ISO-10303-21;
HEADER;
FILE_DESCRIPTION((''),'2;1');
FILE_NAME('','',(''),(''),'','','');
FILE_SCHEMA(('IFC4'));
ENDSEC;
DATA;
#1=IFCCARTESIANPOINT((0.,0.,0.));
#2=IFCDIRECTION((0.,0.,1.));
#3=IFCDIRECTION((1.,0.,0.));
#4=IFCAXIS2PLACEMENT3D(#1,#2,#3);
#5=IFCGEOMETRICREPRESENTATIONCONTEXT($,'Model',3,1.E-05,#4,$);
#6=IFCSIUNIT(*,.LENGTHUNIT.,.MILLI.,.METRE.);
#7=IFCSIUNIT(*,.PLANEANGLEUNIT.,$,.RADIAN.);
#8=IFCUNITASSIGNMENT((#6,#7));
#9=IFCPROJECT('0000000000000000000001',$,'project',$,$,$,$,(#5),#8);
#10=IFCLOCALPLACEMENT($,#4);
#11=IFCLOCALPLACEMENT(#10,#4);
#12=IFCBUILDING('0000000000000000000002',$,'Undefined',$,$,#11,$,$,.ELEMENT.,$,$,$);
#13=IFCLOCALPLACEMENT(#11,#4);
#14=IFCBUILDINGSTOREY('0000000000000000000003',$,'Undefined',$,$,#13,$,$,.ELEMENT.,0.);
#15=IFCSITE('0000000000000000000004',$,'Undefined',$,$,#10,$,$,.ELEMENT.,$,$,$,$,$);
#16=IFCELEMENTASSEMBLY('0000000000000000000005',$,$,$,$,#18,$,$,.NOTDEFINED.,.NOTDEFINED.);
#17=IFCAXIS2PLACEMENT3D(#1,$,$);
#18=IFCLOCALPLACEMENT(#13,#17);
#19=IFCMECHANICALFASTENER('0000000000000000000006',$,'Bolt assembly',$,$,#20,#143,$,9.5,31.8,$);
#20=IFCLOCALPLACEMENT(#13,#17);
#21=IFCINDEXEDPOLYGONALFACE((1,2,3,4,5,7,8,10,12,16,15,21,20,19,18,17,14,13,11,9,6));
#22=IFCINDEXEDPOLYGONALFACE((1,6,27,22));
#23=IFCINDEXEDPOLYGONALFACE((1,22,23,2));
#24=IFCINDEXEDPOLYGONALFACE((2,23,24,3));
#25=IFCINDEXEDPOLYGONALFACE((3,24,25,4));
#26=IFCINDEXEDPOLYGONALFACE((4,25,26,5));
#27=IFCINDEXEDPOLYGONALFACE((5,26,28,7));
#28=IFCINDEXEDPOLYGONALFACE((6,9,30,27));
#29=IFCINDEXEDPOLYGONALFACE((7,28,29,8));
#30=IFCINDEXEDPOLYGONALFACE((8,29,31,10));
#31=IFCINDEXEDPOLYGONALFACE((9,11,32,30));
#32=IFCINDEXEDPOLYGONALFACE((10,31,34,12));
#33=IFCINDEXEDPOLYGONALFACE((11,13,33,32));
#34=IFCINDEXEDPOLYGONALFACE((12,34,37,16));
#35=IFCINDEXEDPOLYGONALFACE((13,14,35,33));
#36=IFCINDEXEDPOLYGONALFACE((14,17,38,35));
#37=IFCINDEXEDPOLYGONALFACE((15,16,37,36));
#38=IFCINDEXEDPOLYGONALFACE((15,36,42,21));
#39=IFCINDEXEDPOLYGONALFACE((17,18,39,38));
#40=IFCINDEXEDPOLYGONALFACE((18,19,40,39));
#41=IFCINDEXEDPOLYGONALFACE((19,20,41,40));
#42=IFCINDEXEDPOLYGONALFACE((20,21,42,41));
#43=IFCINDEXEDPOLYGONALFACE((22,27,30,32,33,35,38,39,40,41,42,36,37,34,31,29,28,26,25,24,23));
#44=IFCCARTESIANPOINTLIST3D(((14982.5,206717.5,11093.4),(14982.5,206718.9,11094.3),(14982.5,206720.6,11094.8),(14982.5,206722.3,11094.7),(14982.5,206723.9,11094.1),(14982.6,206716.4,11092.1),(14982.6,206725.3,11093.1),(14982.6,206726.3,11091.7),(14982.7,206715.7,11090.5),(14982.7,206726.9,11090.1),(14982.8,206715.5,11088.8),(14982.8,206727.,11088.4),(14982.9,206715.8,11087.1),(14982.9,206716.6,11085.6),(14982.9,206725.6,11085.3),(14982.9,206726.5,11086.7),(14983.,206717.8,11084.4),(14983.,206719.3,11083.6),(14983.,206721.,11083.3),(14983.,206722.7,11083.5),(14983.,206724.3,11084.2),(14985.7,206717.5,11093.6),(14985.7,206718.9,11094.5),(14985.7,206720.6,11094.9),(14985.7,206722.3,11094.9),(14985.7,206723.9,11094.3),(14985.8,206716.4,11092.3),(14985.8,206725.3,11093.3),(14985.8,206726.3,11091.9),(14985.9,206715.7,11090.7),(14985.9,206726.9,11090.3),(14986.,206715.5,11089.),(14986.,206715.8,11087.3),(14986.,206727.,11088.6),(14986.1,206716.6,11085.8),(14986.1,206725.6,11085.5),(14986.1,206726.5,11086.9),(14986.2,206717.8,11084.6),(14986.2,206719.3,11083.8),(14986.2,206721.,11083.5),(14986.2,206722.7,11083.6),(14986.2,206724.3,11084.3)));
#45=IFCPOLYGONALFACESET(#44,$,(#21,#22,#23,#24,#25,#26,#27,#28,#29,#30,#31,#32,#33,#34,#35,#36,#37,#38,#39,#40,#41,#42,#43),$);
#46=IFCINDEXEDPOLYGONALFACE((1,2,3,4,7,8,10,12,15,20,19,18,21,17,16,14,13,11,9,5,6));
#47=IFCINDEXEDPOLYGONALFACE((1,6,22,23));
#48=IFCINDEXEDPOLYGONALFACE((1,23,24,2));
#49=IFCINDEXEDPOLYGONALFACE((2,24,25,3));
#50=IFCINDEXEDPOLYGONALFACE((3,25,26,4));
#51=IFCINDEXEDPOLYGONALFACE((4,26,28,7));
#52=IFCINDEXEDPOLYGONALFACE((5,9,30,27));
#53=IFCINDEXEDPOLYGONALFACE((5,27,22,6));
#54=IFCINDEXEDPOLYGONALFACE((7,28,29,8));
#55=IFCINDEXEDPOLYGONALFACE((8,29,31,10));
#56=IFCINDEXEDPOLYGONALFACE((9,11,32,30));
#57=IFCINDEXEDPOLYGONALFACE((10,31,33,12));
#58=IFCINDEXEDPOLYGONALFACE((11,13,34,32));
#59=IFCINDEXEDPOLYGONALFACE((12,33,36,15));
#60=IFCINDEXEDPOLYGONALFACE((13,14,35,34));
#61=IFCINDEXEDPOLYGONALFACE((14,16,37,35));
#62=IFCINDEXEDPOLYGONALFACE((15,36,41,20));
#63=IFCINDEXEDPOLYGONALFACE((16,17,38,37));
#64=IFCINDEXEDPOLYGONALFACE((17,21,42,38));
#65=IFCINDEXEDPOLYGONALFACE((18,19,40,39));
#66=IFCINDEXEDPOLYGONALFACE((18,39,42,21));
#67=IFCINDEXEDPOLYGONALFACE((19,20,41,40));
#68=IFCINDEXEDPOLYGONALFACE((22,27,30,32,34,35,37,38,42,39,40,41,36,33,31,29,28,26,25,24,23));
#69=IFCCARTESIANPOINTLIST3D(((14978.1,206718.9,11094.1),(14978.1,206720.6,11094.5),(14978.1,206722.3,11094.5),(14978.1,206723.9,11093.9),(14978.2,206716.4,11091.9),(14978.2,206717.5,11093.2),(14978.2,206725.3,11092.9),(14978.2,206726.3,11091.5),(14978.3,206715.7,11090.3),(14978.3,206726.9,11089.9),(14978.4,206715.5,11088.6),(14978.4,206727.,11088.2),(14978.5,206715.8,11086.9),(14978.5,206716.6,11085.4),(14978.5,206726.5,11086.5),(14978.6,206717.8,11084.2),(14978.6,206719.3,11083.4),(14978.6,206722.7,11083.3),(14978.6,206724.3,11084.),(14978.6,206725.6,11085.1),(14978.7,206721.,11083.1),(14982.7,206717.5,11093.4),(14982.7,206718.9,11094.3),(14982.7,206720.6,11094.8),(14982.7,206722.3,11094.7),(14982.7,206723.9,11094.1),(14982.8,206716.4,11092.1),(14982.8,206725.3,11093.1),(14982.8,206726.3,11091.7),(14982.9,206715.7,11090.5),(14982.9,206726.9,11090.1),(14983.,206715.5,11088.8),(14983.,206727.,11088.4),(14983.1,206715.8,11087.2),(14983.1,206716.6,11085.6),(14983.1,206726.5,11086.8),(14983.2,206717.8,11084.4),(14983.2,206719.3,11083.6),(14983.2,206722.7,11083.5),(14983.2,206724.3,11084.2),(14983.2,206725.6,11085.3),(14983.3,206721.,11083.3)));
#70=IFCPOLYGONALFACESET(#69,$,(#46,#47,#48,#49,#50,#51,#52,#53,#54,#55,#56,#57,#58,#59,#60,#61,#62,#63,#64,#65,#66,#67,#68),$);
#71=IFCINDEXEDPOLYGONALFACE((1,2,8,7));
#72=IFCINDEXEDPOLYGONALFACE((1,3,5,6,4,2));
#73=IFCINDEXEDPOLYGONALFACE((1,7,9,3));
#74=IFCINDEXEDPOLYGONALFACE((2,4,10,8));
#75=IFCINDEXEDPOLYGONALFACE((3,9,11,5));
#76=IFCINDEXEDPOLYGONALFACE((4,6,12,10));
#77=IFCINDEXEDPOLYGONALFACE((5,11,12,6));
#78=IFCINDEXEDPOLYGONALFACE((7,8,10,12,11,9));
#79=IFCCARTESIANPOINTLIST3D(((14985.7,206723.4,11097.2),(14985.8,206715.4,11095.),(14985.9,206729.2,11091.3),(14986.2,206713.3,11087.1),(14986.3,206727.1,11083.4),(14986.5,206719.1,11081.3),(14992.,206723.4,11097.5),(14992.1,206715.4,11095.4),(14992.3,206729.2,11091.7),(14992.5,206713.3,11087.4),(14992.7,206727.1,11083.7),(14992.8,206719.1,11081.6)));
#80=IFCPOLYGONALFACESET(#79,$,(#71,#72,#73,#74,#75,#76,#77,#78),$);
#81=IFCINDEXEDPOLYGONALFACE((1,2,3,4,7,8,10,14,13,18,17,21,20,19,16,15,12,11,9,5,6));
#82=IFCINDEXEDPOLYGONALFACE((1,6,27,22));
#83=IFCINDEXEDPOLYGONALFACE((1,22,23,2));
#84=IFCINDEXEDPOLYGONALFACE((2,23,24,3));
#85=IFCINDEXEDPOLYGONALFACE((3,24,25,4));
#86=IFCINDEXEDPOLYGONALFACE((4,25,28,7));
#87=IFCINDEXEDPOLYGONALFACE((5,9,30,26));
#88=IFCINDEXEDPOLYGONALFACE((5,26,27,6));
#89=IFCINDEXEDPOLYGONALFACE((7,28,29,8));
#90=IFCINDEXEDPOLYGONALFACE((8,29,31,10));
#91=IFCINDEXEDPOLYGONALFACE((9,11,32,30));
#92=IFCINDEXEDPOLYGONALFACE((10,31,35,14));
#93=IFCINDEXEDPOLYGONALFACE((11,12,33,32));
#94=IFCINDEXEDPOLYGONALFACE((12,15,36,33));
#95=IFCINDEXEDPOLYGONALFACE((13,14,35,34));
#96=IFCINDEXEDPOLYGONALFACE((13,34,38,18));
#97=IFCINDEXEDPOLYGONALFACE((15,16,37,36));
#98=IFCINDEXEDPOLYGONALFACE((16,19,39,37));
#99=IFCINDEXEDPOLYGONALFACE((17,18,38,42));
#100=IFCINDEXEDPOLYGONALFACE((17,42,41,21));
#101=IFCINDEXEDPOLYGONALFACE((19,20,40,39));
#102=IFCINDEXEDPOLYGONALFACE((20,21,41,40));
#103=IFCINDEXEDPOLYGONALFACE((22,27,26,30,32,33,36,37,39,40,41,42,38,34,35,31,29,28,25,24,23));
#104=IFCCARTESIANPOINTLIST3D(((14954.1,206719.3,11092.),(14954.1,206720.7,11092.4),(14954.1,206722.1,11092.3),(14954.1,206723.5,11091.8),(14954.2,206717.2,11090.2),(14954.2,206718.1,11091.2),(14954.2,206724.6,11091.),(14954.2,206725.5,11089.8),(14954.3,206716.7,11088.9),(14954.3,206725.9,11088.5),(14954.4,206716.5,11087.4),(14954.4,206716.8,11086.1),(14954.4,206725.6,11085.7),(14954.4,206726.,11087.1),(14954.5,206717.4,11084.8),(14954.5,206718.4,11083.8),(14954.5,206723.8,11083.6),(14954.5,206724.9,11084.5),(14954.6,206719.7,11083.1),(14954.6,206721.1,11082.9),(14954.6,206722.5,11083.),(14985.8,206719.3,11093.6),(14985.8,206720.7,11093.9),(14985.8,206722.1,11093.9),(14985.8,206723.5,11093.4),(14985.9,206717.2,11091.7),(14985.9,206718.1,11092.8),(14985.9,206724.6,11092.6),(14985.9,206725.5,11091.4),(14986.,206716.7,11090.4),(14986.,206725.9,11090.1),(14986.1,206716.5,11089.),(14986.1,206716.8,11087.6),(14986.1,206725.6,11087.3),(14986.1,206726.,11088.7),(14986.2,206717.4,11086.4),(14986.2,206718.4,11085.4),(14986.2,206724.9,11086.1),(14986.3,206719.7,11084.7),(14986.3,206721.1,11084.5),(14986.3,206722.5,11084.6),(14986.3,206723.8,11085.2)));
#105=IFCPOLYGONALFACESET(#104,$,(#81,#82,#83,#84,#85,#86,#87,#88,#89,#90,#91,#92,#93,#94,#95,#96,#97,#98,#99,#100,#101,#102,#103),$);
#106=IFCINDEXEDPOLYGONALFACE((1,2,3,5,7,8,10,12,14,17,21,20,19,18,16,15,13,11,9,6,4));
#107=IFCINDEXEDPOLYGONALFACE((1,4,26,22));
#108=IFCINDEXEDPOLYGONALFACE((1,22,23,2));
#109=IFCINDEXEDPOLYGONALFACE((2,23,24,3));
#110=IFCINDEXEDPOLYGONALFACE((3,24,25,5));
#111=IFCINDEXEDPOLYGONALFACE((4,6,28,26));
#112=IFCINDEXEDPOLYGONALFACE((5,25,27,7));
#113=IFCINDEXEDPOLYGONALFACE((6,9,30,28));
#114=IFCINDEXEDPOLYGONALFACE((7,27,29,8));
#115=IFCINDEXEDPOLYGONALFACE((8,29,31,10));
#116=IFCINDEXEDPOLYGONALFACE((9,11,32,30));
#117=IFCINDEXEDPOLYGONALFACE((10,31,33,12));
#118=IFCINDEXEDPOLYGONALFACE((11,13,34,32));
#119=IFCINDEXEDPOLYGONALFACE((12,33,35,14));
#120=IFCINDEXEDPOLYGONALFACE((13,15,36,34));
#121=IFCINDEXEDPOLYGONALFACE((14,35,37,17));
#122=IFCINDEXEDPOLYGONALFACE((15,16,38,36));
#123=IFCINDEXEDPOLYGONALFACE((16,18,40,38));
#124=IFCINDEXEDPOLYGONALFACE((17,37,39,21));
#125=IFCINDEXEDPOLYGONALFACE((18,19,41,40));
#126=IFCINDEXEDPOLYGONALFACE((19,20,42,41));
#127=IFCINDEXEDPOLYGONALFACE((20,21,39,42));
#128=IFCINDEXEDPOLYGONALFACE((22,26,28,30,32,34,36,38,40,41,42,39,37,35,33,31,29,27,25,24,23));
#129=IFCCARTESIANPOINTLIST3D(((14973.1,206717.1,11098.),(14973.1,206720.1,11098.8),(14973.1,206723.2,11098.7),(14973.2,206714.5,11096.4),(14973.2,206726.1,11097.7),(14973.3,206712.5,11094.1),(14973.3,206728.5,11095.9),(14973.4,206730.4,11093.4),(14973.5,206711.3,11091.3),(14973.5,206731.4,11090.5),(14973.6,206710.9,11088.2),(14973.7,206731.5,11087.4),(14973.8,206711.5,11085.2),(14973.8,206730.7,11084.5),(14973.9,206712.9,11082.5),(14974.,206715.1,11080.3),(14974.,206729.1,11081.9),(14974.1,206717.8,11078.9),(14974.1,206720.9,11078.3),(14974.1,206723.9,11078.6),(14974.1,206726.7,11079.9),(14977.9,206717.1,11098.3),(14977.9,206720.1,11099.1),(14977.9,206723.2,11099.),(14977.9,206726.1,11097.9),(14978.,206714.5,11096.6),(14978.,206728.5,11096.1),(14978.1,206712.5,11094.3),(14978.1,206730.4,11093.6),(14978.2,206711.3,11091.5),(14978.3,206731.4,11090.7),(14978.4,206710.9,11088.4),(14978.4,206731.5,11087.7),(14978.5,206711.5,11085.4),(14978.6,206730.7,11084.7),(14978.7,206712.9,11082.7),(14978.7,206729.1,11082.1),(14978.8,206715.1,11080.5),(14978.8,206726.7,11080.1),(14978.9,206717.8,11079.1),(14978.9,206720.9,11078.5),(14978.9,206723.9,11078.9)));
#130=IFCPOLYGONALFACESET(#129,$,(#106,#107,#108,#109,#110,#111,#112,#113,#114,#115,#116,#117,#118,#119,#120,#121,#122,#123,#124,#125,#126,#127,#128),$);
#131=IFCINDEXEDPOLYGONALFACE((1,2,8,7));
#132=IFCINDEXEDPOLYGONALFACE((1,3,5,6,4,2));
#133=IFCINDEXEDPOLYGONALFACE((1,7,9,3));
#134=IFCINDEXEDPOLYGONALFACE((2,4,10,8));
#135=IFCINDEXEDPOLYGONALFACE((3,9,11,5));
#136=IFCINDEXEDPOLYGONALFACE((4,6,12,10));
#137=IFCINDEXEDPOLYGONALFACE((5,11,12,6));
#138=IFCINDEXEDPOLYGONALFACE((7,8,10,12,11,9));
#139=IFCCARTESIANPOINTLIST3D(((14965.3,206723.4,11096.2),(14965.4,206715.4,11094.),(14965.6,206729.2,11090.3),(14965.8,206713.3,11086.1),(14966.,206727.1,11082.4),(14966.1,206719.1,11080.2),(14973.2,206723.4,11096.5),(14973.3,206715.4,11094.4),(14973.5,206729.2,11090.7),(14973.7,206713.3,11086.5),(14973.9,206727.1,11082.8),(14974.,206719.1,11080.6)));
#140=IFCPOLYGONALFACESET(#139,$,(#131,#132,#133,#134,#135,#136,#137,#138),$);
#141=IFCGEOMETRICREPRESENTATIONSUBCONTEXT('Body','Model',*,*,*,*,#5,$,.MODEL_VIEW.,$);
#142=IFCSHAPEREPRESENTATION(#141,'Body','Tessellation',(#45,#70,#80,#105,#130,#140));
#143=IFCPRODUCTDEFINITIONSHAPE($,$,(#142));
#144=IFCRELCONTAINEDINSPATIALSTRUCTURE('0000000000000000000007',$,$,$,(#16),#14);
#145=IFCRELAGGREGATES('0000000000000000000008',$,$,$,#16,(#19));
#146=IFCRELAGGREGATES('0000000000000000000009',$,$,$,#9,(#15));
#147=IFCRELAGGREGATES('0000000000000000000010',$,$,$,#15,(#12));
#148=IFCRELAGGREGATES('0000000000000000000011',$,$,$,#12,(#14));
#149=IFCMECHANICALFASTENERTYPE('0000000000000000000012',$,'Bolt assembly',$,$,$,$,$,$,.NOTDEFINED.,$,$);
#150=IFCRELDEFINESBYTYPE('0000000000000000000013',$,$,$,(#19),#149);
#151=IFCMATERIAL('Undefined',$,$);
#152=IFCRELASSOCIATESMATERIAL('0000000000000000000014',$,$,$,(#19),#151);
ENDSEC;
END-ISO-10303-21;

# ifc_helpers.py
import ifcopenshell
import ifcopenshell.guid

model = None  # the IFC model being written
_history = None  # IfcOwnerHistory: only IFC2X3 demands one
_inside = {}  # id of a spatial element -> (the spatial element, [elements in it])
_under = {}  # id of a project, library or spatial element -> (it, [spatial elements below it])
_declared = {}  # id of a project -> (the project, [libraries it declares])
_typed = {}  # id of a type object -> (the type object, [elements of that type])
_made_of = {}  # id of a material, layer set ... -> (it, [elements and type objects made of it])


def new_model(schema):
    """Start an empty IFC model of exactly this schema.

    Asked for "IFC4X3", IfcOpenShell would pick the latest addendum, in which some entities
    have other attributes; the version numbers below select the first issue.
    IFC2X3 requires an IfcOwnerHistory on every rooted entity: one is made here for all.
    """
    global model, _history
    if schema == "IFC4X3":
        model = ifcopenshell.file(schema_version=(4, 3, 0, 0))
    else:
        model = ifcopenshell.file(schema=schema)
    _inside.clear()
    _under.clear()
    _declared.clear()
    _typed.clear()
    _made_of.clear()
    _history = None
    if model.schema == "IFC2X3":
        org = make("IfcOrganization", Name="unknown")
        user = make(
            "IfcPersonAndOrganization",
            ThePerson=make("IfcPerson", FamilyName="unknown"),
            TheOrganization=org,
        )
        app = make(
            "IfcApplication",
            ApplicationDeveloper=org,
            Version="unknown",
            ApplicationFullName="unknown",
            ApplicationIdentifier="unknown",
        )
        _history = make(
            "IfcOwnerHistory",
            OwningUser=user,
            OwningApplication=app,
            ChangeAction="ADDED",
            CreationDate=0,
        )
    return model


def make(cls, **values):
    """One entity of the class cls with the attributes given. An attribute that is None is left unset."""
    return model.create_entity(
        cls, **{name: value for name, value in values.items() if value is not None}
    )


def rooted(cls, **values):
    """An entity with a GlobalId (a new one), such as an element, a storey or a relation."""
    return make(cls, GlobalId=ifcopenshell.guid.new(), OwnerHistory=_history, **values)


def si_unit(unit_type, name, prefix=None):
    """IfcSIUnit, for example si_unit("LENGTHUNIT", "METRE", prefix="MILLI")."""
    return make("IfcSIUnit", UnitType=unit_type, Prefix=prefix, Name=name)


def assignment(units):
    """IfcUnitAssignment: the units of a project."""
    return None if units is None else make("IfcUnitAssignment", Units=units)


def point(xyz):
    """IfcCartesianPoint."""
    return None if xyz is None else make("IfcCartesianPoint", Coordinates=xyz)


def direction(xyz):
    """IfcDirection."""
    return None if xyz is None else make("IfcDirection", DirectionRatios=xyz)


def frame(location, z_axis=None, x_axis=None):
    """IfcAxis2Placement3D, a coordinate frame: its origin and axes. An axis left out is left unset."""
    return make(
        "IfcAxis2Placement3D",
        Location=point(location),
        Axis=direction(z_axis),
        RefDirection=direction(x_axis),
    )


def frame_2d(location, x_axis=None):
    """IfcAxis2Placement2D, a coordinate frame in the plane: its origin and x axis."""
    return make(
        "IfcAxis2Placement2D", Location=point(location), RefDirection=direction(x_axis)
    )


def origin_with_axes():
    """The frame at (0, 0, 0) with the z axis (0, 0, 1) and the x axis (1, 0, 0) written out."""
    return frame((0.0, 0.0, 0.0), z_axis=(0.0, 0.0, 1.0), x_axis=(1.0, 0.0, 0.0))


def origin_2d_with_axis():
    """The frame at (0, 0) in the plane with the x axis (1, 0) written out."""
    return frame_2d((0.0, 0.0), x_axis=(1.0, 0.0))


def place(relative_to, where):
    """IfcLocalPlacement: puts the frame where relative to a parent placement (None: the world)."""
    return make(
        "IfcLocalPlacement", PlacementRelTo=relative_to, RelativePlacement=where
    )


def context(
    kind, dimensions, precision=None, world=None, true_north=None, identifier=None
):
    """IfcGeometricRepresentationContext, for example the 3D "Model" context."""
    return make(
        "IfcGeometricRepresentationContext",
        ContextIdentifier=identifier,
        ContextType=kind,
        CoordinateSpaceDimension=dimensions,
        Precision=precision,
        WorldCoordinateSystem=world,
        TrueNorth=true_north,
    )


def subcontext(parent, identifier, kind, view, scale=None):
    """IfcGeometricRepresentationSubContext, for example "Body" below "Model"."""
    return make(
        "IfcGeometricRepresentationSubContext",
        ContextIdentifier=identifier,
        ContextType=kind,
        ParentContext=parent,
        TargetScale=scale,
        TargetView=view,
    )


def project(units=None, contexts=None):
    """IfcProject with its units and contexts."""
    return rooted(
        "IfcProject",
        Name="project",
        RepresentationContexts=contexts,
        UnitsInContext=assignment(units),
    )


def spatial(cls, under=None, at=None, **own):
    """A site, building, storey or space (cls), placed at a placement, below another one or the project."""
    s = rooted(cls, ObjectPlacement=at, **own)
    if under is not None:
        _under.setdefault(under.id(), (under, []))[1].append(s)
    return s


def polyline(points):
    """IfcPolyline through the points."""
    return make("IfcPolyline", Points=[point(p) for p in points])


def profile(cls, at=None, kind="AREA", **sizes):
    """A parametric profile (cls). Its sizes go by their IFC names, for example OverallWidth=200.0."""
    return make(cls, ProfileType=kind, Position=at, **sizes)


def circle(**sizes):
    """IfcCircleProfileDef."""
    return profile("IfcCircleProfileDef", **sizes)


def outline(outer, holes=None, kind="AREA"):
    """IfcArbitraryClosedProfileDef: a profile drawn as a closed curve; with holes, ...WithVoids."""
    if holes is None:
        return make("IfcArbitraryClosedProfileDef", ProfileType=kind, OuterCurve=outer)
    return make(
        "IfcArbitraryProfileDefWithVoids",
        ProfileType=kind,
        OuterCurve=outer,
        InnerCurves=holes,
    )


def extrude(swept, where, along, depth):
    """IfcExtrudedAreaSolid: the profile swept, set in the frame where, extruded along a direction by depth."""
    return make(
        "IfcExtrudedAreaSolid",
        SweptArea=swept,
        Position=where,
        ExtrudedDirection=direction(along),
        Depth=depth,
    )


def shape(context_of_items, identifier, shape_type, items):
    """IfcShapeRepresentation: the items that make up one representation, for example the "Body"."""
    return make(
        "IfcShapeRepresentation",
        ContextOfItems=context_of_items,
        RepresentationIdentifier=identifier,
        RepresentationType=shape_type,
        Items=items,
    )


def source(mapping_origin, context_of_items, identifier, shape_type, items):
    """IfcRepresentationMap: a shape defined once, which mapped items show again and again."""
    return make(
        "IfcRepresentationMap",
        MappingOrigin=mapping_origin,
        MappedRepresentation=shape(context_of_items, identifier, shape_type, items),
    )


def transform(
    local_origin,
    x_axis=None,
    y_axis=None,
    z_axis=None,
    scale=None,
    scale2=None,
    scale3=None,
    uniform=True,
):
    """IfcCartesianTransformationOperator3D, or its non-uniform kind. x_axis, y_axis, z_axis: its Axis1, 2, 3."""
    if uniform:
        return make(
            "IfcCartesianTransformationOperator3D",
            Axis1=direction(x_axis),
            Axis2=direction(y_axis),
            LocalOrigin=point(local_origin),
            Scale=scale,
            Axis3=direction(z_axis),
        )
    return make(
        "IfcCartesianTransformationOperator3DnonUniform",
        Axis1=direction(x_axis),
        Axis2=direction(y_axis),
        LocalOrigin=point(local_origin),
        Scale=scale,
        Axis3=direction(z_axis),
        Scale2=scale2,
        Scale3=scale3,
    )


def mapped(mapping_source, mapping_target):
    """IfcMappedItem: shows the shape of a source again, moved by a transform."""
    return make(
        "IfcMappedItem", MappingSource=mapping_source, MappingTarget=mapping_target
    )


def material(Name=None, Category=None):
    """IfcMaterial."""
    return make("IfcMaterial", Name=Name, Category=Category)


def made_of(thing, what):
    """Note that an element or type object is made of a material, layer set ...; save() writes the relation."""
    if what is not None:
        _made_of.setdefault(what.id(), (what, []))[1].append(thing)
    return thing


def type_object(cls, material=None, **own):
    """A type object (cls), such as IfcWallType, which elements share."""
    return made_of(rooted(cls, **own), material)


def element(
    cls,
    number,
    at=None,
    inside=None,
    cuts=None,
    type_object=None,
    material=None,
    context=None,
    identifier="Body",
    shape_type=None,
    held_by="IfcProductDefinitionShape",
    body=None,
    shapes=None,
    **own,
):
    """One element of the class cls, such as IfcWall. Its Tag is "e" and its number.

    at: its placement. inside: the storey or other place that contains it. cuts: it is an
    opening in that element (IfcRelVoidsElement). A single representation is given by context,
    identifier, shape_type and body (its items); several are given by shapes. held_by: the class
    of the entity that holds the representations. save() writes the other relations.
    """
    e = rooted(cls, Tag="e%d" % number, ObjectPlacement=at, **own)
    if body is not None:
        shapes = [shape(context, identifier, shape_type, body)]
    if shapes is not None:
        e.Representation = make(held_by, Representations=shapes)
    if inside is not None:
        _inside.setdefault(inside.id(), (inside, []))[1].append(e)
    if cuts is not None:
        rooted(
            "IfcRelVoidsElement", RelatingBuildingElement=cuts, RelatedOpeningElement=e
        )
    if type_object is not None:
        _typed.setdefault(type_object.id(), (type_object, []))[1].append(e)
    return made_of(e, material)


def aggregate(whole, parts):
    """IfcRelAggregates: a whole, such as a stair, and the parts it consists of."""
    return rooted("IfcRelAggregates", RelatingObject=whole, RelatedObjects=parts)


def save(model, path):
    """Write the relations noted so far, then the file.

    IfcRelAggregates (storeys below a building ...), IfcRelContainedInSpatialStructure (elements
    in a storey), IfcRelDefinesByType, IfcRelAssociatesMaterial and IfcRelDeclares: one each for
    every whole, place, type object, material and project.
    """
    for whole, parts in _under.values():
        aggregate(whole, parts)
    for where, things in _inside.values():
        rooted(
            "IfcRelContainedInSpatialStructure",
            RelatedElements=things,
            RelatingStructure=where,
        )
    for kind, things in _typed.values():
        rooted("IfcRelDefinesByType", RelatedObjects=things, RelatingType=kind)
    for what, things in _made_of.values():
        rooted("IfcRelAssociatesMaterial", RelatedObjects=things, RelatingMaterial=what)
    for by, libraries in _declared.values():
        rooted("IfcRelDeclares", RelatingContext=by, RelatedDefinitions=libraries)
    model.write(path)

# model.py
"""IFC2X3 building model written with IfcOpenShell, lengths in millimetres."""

from ifc_helpers import new_model, si_unit, frame, origin_with_axes, origin_2d_with_axis, place, context, subcontext, project, spatial, polyline, circle, outline, extrude, source, transform, mapped, material, type_object, element, aggregate, save


model = new_model("IFC2X3")

# Units and contexts
model_context = context("Model", 3, precision=1e-05, world=origin_with_axes())
body_context = subcontext(model_context, "Body", "Model", "MODEL_VIEW")
ifc_project = project(units=[si_unit("LENGTHUNIT", "METRE", prefix="MILLI"), si_unit("PLANEANGLEUNIT", "RADIAN")], contexts=[model_context])

# Site, building, storey
site_placement = place(None, origin_with_axes())
site = spatial("IfcSite", under=ifc_project, at=site_placement, Name="Undefined", CompositionType="ELEMENT")
building_placement = place(site_placement, origin_with_axes())
building = spatial("IfcBuilding", under=site, at=building_placement, Name="Undefined", CompositionType="ELEMENT")
storey_placement = place(building_placement, origin_with_axes())
storey = spatial("IfcBuildingStorey", under=building, at=storey_placement, Name="Undefined", CompositionType="ELEMENT", Elevation=0.0)

# Element assembly
assembly_1_placement = place(storey_placement, origin_with_axes())
assembly_1 = element("IfcElementAssembly", 1, at=assembly_1_placement, inside=storey, AssemblyPlace="NOTDEFINED", PredefinedType="NOTDEFINED")

# Mechanical fastener
ifc_material_1 = material(Name="Undefined")
mechanical_fastener_type = type_object("IfcMechanicalFastenerType", Name="Bolt assembly")
shared_shape_1 = source(origin_with_axes(), body_context, "Body", "SweptSolid", [
    extrude(circle(Radius=5.8, at=origin_2d_with_axis()), frame((0.0, -7.6, 0.0), z_axis=(0.0, 1.0, 0.0), x_axis=(1.0, 0.0, 0.0)), (0.0, 0.0, 1.0), 3.2),
    extrude(circle(Radius=5.8, at=origin_2d_with_axis()), frame((0.0, -4.6, 0.0), z_axis=(0.0, 1.0, 0.0), x_axis=(1.0, 0.0, 0.0)), (0.0, 0.0, 1.0), 4.6),
    extrude(outline(polyline([(7.1, -4.1), (7.1, 4.1), (0.0, 8.2), (-7.1, 4.1), (-7.1, -4.1), (0.0, -8.2), (7.1, -4.1)])), frame((0.0, -14.0, 0.0), z_axis=(0.0, 1.0, 0.0), x_axis=(1.0, 0.0, 0.0)), (0.0, 0.0, 1.0), 6.3),
    extrude(circle(Radius=4.8, at=origin_2d_with_axis()), frame((0.0, -7.7, 0.0), z_axis=(0.0, 1.0, 0.0), x_axis=(1.0, 0.0, 0.0)), (0.0, 0.0, 1.0), 31.8),
    extrude(circle(Radius=10.3, at=origin_2d_with_axis()), frame((0.0, 0.0, 0.0), z_axis=(0.0, 1.0, 0.0), x_axis=(1.0, 0.0, 0.0)), (0.0, 0.0, 1.0), 4.8),
    extrude(outline(polyline([(7.1, -4.1), (7.1, 4.1), (0.0, 8.2), (-7.1, 4.1), (-7.1, -4.1), (0.0, -8.2), (7.1, -4.1)])), frame((0.0, 4.8, 0.0), z_axis=(0.0, 1.0, 0.0), x_axis=(1.0, 0.0, 0.0)), (0.0, 0.0, 1.0), 7.9),
])
mechanical_fastener_1_placement = place(assembly_1_placement, frame((14978.4, 206721.2, 11088.8), z_axis=(-0.035282, -0.707107, 0.706226), x_axis=(-0.035282, 0.707107, 0.706226)))
mechanical_fastener_1 = element("IfcMechanicalFastener", 2, at=mechanical_fastener_1_placement, type_object=mechanical_fastener_type, material=ifc_material_1, Name="Bolt assembly", NominalDiameter=9.5, NominalLength=31.8, context=body_context, shape_type="MappedRepresentation", body=[
    mapped(shared_shape_1, transform((0.0, 0.0, 0.0))),
])
aggregate(assembly_1, [mechanical_fastener_1])

save(model, "model.ifc")
